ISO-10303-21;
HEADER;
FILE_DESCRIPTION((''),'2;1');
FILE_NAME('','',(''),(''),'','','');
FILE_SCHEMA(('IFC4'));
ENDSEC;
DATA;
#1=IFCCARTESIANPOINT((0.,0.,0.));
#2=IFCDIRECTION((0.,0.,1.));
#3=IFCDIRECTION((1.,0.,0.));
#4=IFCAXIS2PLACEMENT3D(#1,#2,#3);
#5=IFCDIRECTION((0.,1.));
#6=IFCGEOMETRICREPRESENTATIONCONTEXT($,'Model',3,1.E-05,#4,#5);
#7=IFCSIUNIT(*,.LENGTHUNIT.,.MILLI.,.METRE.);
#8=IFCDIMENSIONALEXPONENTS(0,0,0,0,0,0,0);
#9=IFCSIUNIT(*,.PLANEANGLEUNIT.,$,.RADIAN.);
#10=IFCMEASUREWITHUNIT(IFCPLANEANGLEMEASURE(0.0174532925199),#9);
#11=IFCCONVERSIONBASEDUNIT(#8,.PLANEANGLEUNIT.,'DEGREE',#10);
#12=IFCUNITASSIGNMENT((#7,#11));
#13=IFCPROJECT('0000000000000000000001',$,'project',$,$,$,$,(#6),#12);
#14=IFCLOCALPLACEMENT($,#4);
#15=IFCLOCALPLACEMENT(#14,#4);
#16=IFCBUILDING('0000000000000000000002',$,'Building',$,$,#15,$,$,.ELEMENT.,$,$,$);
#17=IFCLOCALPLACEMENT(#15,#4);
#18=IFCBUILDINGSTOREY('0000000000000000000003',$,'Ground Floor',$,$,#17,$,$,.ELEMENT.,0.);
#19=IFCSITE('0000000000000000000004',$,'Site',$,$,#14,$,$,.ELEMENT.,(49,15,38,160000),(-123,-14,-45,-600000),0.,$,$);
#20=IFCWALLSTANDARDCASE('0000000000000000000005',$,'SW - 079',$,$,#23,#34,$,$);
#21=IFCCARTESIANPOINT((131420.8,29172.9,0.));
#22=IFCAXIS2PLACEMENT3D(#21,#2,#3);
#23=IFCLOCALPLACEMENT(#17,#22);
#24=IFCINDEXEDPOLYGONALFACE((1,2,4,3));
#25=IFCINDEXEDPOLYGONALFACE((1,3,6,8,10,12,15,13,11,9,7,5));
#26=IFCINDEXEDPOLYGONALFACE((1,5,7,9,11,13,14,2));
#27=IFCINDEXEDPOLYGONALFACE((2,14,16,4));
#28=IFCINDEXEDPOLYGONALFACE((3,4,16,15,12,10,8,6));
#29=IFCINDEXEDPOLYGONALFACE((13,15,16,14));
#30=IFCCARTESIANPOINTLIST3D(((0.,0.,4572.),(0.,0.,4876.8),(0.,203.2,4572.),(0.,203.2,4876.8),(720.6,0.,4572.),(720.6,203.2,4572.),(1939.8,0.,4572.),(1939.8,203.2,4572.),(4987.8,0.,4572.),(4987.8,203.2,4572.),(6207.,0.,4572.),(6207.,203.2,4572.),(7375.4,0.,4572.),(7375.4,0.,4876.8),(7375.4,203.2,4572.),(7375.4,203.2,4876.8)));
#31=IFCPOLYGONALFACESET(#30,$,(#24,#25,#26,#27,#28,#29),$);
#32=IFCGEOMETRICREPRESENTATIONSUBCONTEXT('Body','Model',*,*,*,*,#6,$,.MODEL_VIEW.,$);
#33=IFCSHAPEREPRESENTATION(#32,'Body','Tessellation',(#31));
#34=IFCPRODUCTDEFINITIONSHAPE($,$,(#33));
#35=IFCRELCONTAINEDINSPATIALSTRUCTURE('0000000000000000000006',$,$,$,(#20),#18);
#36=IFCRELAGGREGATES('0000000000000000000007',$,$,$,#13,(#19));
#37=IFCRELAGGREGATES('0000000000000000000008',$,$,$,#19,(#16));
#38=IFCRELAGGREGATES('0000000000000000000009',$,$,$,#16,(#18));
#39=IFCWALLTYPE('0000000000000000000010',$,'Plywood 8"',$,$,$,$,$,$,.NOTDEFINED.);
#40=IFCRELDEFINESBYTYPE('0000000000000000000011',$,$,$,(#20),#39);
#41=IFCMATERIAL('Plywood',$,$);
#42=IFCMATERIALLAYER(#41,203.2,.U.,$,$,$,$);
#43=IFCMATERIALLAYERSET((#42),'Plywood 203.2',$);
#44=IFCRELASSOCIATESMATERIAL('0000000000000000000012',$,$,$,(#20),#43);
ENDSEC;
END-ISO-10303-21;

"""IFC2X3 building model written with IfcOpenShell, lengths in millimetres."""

from ifc_helpers import new_model, entity, si_unit, converted_unit, direction, frame, origin_with_axes, origin_2d_with_axis, place, context, subcontext, project, spatial, polyline, rectangle, outline, extrude, material, layer, layer_set, layer_usage, type_object, element, save


model = new_model("IFC2X3")

# Units and contexts
model_context = context("Model", 3, precision=1e-05, world=origin_with_axes(), true_north=direction((0.0, 1.0)))
body_context = subcontext(model_context, "Body", "Model", "MODEL_VIEW")
ifc_project = project(units=[si_unit("LENGTHUNIT", "METRE", prefix="MILLI"), converted_unit("PLANEANGLEUNIT", "DEGREE", entity("IfcPlaneAngleMeasure", 0.0174532925199), si_unit("PLANEANGLEUNIT", "RADIAN"), dimensions=[0, 0, 0, 0, 0, 0, 0])], contexts=[model_context])

# Site, building, storey
site_placement = place(None, origin_with_axes())
site = spatial("IfcSite", under=ifc_project, at=site_placement, Name="Site", CompositionType="ELEMENT", RefLatitude=(49, 15, 38, 160000), RefLongitude=(-123, -14, -45, -600000), RefElevation=0.0)
building_placement = place(site_placement, origin_with_axes())
building = spatial("IfcBuilding", under=site, at=building_placement, Name="Building", CompositionType="ELEMENT")
storey_placement = place(building_placement, origin_with_axes())
storey = spatial("IfcBuildingStorey", under=building, at=storey_placement, Name="Ground Floor", CompositionType="ELEMENT", Elevation=0.0)

# Wall, openings
ifc_material_1 = material(Name="Plywood")
ifc_layer_1 = layer(ifc_material_1, 203.2, ventilated="UNKNOWN")
ifc_layer_set_1 = layer_set([ifc_layer_1], Name="Plywood 203.2")
wall_type_1 = type_object("IfcWallType", Name="Plywood 8\"", PredefinedType="NOTDEFINED")
ifc_layer_usage_1 = layer_usage(ifc_layer_set_1, "AXIS2", "POSITIVE", 0.0)
wall_1_placement = place(storey_placement, frame((131420.8, 29172.9, 0.0), z_axis=(0.0, 0.0, 1.0), x_axis=(1.0, 0.0, 0.0)))
wall_1 = element("IfcWallStandardCase", 1, at=wall_1_placement, inside=storey, type_object=wall_type_1, material=ifc_layer_usage_1, Name="SW - 079", context=body_context, shape_type="SweptSolid", body=[
    extrude(outline(polyline([(0.0, 0.0), (7375.4, 0.0), (7375.4, 203.2), (0.0, 203.2), (0.0, 0.0)])), origin_with_axes(), (0.0, 0.0, 1.0), 4876.8),
])
opening_1_placement = place(wall_1_placement, frame((207.9, 0.0, 0.0), z_axis=(0.0, 0.0, 1.0), x_axis=(1.0, 0.0, 0.0)))
element("IfcOpeningElement", 2, at=opening_1_placement, cuts=wall_1, context=body_context, shape_type="SweptSolid", body=[
    extrude(rectangle(XDim=1025.4, YDim=4572.0, at=origin_2d_with_axis()), frame((0.0, -203.2, 2286.0), z_axis=(0.0, 1.0, 0.0), x_axis=(1.0, 0.0, 0.0)), (0.0, 0.0, 1.0), 609.6),
])
opening_2_placement = place(wall_1_placement, frame((1330.2, 0.0, 0.0), z_axis=(0.0, 0.0, 1.0), x_axis=(1.0, 0.0, 0.0)))
element("IfcOpeningElement", 3, at=opening_2_placement, cuts=wall_1, context=body_context, shape_type="SweptSolid", body=[
    extrude(rectangle(XDim=1219.2, YDim=4572.0, at=origin_2d_with_axis()), frame((0.0, -203.2, 2286.0), z_axis=(0.0, 1.0, 0.0), x_axis=(1.0, 0.0, 0.0)), (0.0, 0.0, 1.0), 609.6),
])
opening_3_placement = place(wall_1_placement, frame((5597.4, 0.0, 0.0), z_axis=(0.0, 0.0, 1.0), x_axis=(1.0, 0.0, 0.0)))
element("IfcOpeningElement", 4, at=opening_3_placement, cuts=wall_1, context=body_context, shape_type="SweptSolid", body=[
    extrude(rectangle(XDim=1219.2, YDim=4572.0, at=origin_2d_with_axis()), frame((0.0, -203.2, 2286.0), z_axis=(0.0, 1.0, 0.0), x_axis=(1.0, 0.0, 0.0)), (0.0, 0.0, 1.0), 609.6),
])
opening_4_placement = place(wall_1_placement, frame((6791.2, 0.0, 0.0), z_axis=(0.0, 0.0, 1.0), x_axis=(1.0, 0.0, 0.0)))
element("IfcOpeningElement", 5, at=opening_4_placement, cuts=wall_1, context=body_context, shape_type="SweptSolid", body=[
    extrude(rectangle(XDim=1168.4, YDim=4572.0, at=origin_2d_with_axis()), frame((0.0, -203.2, 2286.0), z_axis=(0.0, -1.0, 0.0), x_axis=(-1.0, 0.0, 0.0)), (0.0, 0.0, -1.0), 609.6),
])
opening_5_placement = place(wall_1_placement, frame((3463.8, 0.0, 0.0), z_axis=(0.0, 0.0, 1.0), x_axis=(1.0, 0.0, 0.0)))
element("IfcOpeningElement", 6, at=opening_5_placement, cuts=wall_1, context=body_context, shape_type="SweptSolid", body=[
    extrude(rectangle(XDim=3048.0, YDim=4572.0, at=origin_2d_with_axis()), frame((0.0, -203.2, 2286.0), z_axis=(0.0, 1.0, 0.0), x_axis=(1.0, 0.0, 0.0)), (0.0, 0.0, 1.0), 609.6),
])

save(model, "model.ifc")
